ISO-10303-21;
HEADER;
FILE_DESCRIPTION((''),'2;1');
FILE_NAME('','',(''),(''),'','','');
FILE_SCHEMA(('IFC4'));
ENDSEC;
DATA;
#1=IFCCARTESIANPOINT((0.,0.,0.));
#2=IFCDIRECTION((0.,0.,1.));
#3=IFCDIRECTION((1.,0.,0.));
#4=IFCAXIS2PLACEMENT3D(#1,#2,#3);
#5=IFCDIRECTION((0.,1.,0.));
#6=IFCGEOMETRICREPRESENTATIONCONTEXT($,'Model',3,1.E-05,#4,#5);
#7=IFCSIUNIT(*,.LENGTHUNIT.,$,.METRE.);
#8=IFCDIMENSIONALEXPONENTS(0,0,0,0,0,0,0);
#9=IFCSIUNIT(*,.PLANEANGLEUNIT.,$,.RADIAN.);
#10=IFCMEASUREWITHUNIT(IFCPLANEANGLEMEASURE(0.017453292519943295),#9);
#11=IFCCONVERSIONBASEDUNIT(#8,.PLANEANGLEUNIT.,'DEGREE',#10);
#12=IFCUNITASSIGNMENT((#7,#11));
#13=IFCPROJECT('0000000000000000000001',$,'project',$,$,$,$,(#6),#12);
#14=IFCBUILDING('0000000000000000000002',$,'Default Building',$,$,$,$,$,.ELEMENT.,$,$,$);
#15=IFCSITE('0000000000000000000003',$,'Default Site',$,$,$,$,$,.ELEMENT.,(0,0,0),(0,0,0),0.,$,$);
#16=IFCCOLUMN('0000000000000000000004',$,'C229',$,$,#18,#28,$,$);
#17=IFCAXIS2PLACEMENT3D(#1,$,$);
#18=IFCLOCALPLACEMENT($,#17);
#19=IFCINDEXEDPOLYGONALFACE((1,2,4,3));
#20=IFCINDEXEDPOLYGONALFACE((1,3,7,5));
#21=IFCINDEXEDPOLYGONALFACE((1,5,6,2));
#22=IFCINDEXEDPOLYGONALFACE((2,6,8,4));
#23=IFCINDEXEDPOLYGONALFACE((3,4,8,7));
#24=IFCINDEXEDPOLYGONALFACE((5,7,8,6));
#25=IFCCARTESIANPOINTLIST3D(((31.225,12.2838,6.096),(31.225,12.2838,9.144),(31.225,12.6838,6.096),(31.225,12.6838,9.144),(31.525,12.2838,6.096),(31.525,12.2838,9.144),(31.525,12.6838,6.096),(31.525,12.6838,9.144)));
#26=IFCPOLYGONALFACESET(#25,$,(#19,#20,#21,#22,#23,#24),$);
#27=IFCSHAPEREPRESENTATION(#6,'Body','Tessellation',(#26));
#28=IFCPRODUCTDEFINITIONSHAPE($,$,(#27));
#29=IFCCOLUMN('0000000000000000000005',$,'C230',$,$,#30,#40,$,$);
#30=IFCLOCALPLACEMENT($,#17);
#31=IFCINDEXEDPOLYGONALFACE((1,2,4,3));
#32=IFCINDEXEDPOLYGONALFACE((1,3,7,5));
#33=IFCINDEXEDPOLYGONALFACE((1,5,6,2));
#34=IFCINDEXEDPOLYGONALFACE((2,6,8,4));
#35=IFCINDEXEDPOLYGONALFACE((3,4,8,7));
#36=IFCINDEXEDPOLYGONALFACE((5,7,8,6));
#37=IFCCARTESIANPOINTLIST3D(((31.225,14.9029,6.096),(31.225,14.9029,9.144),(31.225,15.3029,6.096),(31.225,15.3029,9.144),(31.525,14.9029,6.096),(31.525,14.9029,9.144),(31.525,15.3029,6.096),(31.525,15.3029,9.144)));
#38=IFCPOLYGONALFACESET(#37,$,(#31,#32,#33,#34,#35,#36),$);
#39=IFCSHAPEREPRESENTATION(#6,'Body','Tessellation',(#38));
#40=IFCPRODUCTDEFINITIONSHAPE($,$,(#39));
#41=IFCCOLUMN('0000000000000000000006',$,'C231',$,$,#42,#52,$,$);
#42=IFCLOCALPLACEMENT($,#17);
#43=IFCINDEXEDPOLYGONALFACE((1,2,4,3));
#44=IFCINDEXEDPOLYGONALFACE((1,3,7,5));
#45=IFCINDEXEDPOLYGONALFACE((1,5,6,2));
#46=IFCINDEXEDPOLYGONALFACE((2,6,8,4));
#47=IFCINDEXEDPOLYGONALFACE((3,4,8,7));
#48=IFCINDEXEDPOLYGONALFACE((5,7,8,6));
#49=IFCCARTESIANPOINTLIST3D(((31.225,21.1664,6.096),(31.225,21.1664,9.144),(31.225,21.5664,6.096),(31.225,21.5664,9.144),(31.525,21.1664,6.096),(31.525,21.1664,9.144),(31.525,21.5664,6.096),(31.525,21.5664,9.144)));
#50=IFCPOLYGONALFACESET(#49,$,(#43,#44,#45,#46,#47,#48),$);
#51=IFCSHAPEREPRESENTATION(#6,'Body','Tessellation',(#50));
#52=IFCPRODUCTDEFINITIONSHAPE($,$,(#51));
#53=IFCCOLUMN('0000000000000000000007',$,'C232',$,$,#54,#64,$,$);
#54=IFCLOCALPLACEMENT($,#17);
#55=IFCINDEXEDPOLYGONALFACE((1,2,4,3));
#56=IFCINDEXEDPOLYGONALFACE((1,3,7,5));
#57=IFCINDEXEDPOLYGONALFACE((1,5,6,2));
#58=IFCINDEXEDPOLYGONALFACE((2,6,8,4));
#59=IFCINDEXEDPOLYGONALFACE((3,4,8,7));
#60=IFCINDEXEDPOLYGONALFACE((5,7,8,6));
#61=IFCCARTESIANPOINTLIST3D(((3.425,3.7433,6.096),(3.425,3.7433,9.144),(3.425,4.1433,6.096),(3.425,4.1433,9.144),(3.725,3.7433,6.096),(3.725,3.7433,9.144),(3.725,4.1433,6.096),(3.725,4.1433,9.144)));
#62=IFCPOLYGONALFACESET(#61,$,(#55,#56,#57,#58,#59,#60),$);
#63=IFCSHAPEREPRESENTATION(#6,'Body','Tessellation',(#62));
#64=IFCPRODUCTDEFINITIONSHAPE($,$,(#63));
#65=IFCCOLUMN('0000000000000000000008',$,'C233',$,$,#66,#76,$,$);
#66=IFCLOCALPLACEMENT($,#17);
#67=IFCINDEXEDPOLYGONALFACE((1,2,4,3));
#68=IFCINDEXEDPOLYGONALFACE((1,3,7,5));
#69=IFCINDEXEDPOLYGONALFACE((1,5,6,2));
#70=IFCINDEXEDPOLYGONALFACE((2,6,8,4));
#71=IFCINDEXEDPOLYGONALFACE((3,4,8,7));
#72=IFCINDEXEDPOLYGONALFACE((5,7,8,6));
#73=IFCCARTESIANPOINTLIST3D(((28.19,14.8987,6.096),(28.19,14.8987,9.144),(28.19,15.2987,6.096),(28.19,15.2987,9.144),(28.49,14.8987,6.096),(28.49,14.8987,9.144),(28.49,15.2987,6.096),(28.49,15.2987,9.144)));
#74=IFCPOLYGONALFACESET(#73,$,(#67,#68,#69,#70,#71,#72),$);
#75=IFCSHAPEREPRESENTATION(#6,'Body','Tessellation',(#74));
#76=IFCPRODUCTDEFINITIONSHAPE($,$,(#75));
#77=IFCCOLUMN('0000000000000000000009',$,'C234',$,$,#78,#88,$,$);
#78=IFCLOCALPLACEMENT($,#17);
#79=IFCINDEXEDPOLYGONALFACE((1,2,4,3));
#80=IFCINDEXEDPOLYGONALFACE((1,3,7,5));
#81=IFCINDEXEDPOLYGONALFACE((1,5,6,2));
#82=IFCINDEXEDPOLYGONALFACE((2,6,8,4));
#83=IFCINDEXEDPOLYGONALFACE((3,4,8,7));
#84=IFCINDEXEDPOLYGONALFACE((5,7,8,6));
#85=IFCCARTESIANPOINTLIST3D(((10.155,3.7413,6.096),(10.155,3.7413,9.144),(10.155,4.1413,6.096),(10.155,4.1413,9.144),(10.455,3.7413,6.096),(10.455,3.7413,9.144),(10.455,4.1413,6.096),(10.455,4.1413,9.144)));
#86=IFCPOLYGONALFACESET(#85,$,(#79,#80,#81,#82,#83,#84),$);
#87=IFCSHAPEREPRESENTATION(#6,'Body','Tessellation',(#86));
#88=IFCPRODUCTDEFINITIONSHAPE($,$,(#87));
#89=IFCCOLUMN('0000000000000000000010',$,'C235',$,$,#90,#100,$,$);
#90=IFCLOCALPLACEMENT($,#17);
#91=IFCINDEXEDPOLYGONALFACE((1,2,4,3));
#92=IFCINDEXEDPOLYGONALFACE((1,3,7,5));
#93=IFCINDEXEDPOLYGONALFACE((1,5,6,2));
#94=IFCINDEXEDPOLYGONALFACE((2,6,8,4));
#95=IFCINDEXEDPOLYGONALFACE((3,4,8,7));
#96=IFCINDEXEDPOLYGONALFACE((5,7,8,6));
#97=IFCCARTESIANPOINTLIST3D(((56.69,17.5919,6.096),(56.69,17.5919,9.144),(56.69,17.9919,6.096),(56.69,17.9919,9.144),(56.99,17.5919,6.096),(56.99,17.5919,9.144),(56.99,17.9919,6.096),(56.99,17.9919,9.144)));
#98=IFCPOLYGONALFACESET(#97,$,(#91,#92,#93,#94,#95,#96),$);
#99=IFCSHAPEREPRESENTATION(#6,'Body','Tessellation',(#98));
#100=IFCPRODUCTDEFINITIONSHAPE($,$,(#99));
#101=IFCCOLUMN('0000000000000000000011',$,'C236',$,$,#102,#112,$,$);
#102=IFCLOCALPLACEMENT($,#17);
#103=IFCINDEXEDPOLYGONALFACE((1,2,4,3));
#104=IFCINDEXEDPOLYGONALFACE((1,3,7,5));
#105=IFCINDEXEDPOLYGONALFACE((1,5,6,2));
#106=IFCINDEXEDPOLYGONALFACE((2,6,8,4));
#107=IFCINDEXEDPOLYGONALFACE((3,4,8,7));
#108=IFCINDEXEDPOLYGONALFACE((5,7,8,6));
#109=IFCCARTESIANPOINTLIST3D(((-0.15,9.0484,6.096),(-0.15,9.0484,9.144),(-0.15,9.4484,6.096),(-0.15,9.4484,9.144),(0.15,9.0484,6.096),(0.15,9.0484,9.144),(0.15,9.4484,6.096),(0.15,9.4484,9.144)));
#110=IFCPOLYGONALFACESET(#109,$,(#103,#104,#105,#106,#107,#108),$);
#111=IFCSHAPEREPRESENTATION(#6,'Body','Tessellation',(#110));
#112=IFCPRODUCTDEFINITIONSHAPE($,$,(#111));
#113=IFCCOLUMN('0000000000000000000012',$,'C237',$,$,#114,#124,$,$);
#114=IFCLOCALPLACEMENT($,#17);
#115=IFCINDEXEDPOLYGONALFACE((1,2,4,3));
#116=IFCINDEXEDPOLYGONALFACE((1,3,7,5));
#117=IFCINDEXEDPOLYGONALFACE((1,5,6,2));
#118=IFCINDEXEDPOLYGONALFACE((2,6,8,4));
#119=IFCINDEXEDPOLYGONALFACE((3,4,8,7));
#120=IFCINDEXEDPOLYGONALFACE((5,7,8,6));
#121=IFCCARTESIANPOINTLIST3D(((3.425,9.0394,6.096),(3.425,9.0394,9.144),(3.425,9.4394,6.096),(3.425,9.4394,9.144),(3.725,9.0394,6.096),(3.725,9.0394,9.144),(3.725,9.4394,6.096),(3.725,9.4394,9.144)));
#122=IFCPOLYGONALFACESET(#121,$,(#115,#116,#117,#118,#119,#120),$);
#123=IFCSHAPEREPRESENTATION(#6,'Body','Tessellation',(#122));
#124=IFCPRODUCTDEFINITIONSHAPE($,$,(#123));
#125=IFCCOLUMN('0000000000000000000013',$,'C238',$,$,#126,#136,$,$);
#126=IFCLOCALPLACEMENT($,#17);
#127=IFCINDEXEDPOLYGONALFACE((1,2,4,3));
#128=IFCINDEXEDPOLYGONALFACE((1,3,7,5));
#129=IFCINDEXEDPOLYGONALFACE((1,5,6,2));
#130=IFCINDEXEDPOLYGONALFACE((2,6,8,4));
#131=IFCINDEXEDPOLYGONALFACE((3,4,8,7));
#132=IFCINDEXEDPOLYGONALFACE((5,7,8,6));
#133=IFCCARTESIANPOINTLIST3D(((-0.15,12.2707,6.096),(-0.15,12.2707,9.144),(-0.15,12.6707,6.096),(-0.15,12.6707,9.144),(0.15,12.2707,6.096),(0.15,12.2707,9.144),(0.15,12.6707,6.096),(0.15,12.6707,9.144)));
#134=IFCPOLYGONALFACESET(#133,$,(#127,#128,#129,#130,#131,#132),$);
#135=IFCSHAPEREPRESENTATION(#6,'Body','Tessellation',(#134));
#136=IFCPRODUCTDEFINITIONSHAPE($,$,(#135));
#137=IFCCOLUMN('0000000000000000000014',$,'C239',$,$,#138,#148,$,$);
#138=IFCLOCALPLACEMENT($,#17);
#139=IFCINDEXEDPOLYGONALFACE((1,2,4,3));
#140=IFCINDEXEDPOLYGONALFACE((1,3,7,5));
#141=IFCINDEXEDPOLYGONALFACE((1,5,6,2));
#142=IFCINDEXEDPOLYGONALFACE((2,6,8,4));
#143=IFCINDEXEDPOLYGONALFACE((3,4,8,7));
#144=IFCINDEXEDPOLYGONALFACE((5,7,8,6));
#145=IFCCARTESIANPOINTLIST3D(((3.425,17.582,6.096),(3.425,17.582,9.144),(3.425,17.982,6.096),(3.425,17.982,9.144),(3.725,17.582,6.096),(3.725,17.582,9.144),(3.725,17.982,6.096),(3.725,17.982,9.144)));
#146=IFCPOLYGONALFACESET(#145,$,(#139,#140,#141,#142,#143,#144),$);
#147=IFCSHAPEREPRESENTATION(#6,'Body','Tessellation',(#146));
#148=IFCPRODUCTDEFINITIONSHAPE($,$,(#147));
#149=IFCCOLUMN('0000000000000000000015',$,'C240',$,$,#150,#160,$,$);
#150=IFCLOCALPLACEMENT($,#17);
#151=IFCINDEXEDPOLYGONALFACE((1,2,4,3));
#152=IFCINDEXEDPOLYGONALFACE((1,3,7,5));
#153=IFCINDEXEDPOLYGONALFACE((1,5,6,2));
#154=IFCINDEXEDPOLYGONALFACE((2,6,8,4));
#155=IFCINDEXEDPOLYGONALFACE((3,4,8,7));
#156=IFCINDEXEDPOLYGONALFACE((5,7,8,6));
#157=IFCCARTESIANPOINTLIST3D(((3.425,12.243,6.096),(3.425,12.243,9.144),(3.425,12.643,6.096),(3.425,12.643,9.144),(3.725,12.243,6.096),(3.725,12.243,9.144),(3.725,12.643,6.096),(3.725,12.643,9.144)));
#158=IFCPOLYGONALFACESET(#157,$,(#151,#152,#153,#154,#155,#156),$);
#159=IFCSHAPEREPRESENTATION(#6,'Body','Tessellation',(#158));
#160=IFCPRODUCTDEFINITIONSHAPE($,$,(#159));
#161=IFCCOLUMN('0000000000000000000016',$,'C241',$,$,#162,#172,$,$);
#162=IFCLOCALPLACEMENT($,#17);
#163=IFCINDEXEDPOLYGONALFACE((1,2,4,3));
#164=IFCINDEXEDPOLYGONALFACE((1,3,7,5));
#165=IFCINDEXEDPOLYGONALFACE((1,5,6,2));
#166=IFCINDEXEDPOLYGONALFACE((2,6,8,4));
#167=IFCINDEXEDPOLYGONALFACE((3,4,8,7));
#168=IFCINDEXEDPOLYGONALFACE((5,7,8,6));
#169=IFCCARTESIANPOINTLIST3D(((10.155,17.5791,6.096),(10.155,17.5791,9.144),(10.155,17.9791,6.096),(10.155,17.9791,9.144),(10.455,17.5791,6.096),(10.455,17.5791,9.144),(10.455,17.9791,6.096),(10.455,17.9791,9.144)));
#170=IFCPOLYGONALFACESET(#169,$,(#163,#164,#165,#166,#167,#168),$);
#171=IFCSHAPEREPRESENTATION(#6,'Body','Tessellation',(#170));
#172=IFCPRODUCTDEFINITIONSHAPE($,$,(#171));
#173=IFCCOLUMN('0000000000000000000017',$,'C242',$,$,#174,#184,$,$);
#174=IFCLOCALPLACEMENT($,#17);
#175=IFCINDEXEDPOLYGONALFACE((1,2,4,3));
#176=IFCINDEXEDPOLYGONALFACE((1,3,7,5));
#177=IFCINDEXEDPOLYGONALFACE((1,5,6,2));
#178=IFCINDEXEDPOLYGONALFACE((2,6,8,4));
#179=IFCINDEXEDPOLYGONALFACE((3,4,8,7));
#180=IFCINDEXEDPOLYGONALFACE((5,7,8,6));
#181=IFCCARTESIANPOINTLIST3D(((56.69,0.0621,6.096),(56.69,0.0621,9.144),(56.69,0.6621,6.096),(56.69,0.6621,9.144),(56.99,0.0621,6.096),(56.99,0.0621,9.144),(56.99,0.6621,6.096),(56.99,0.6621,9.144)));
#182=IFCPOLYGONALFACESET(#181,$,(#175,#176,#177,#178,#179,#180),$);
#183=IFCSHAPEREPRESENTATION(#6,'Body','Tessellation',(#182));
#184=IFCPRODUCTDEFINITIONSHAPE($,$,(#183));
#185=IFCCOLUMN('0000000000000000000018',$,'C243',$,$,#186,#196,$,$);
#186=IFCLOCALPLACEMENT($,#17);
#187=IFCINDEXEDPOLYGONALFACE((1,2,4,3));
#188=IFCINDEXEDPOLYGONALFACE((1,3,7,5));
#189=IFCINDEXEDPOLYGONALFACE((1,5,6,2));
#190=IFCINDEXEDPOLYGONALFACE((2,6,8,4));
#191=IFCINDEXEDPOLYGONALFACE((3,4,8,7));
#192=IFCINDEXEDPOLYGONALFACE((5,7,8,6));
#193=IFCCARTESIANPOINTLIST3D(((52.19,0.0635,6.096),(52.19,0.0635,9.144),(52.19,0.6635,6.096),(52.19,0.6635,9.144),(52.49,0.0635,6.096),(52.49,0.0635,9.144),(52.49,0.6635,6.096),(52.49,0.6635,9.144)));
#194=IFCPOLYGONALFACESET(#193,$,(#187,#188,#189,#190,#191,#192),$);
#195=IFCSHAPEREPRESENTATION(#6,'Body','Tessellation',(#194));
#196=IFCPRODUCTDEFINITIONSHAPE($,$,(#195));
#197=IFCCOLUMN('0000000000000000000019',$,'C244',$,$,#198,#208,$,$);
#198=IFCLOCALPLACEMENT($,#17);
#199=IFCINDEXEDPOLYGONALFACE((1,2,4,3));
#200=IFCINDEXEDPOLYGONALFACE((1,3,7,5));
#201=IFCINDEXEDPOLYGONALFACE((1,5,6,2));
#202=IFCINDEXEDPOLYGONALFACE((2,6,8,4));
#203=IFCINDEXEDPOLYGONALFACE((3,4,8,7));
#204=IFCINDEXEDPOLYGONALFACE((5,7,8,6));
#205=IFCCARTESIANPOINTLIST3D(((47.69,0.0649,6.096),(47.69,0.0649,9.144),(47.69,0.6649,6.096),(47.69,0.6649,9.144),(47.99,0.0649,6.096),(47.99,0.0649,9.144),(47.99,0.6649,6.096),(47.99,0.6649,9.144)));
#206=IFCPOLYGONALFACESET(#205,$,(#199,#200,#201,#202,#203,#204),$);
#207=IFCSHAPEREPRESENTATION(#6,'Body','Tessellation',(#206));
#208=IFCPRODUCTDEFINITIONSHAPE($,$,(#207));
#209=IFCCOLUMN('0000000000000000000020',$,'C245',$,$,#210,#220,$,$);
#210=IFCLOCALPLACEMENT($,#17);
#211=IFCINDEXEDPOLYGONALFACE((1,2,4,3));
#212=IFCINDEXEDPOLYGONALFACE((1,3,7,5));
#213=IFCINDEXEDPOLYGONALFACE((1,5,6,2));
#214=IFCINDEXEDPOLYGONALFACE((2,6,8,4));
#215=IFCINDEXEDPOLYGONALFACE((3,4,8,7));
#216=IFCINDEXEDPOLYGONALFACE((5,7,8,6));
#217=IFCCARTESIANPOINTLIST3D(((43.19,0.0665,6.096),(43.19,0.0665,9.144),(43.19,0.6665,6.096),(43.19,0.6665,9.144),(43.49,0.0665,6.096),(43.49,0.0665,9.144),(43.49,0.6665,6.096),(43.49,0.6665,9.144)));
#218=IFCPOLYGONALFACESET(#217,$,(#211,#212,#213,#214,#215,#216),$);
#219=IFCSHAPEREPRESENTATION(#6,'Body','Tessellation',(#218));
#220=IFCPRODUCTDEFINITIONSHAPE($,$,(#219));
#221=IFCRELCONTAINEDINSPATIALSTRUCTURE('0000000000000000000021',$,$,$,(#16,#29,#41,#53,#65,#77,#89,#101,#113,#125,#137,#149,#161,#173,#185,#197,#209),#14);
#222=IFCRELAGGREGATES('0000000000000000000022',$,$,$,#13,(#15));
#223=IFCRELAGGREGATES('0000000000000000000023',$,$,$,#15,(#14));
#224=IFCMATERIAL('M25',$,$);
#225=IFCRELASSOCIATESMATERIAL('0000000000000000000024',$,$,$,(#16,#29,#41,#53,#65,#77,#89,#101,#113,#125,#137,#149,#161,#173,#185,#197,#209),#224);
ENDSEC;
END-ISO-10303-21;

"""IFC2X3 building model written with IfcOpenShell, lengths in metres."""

from ifc_helpers import new_model, entity, si_unit, converted_unit, direction, frame, frame_2d, origin_with_axes, place, context, project, spatial, rectangle, extrude, material, element, save


model = new_model("IFC2X3")

# Units and contexts
model_context = context("Model", 3, precision=1e-05, world=origin_with_axes(), true_north=direction((0.0, 1.0, 0.0)))
ifc_project = project(units=[si_unit("LENGTHUNIT", "METRE"), converted_unit("PLANEANGLEUNIT", "DEGREE", entity("IfcPlaneAngleMeasure", 0.017453292519943295), si_unit("PLANEANGLEUNIT", "RADIAN"), dimensions=[0, 0, 0, 0, 0, 0, 0])], contexts=[model_context])

# Site, building
site = spatial("IfcSite", under=ifc_project, Name="Default Site", CompositionType="ELEMENT", RefLatitude=(0, 0, 0), RefLongitude=(0, 0, 0), RefElevation=0.0)
building = spatial("IfcBuilding", under=site, Name="Default Building", CompositionType="ELEMENT")

# Columns
ifc_material = material(Name="M25")
placement = place(None, origin_with_axes())
element("IfcColumn", 1, at=placement, inside=building, material=ifc_material, Name="C229", context=model_context, shape_type="SweptSolid", body=[
    extrude(rectangle(XDim=0.3, YDim=0.4, at=frame_2d((0.0, 0.0), x_axis=(1.0, 0.0, 0.0))), frame((31.375, 12.4838, 6.096), z_axis=(0.0, 0.0, 1.0), x_axis=(1.0, 0.0, 0.0)), (0.0, 0.0, 1.0), 3.048),
])
element("IfcColumn", 2, at=placement, inside=building, material=ifc_material, Name="C230", context=model_context, shape_type="SweptSolid", body=[
    extrude(rectangle(XDim=0.3, YDim=0.4, at=frame_2d((0.0, 0.0), x_axis=(1.0, 0.0, 0.0))), frame((31.375, 15.1029, 6.096), z_axis=(0.0, 0.0, 1.0), x_axis=(1.0, 0.0, 0.0)), (0.0, 0.0, 1.0), 3.048),
])
element("IfcColumn", 3, at=placement, inside=building, material=ifc_material, Name="C231", context=model_context, shape_type="SweptSolid", body=[
    extrude(rectangle(XDim=0.3, YDim=0.4, at=frame_2d((0.0, 0.0), x_axis=(1.0, 0.0, 0.0))), frame((31.375, 21.3664, 6.096), z_axis=(0.0, 0.0, 1.0), x_axis=(1.0, 0.0, 0.0)), (0.0, 0.0, 1.0), 3.048),
])
element("IfcColumn", 4, at=placement, inside=building, material=ifc_material, Name="C232", context=model_context, shape_type="SweptSolid", body=[
    extrude(rectangle(XDim=0.3, YDim=0.4, at=frame_2d((0.0, 0.0), x_axis=(1.0, 0.0, 0.0))), frame((3.575, 3.9433, 6.096), z_axis=(0.0, 0.0, 1.0), x_axis=(1.0, 0.0, 0.0)), (0.0, 0.0, 1.0), 3.048),
])
element("IfcColumn", 5, at=placement, inside=building, material=ifc_material, Name="C233", context=model_context, shape_type="SweptSolid", body=[
    extrude(rectangle(XDim=0.3, YDim=0.4, at=frame_2d((0.0, 0.0), x_axis=(1.0, 0.0, 0.0))), frame((28.34, 15.0987, 6.096), z_axis=(0.0, 0.0, 1.0), x_axis=(1.0, 0.0, 0.0)), (0.0, 0.0, 1.0), 3.048),
])
element("IfcColumn", 6, at=placement, inside=building, material=ifc_material, Name="C234", context=model_context, shape_type="SweptSolid", body=[
    extrude(rectangle(XDim=0.3, YDim=0.4, at=frame_2d((0.0, 0.0), x_axis=(1.0, 0.0, 0.0))), frame((10.305, 3.9413, 6.096), z_axis=(0.0, 0.0, 1.0), x_axis=(1.0, 0.0, 0.0)), (0.0, 0.0, 1.0), 3.048),
])
element("IfcColumn", 7, at=placement, inside=building, material=ifc_material, Name="C235", context=model_context, shape_type="SweptSolid", body=[
    extrude(rectangle(XDim=0.3, YDim=0.4, at=frame_2d((0.0, 0.0), x_axis=(1.0, 0.0, 0.0))), frame((56.84, 17.7919, 6.096), z_axis=(0.0, 0.0, 1.0), x_axis=(1.0, 0.0, 0.0)), (0.0, 0.0, 1.0), 3.048),
])
element("IfcColumn", 8, at=placement, inside=building, material=ifc_material, Name="C236", context=model_context, shape_type="SweptSolid", body=[
    extrude(rectangle(XDim=0.3, YDim=0.4, at=frame_2d((0.0, 0.0), x_axis=(1.0, 0.0, 0.0))), frame((0.0, 9.2484, 6.096), z_axis=(0.0, 0.0, 1.0), x_axis=(1.0, 0.0, 0.0)), (0.0, 0.0, 1.0), 3.048),
])
element("IfcColumn", 9, at=placement, inside=building, material=ifc_material, Name="C237", context=model_context, shape_type="SweptSolid", body=[
    extrude(rectangle(XDim=0.3, YDim=0.4, at=frame_2d((0.0, 0.0), x_axis=(1.0, 0.0, 0.0))), frame((3.575, 9.2394, 6.096), z_axis=(0.0, 0.0, 1.0), x_axis=(1.0, 0.0, 0.0)), (0.0, 0.0, 1.0), 3.048),
])
element("IfcColumn", 10, at=placement, inside=building, material=ifc_material, Name="C238", context=model_context, shape_type="SweptSolid", body=[
    extrude(rectangle(XDim=0.3, YDim=0.4, at=frame_2d((0.0, 0.0), x_axis=(1.0, 0.0, 0.0))), frame((0.0, 12.4707, 6.096), z_axis=(0.0, 0.0, 1.0), x_axis=(1.0, 0.0, 0.0)), (0.0, 0.0, 1.0), 3.048),
])
element("IfcColumn", 11, at=placement, inside=building, material=ifc_material, Name="C239", context=model_context, shape_type="SweptSolid", body=[
    extrude(rectangle(XDim=0.3, YDim=0.4, at=frame_2d((0.0, 0.0), x_axis=(1.0, 0.0, 0.0))), frame((3.575, 17.782, 6.096), z_axis=(0.0, 0.0, 1.0), x_axis=(1.0, 0.0, 0.0)), (0.0, 0.0, 1.0), 3.048),
])
element("IfcColumn", 12, at=placement, inside=building, material=ifc_material, Name="C240", context=model_context, shape_type="SweptSolid", body=[
    extrude(rectangle(XDim=0.3, YDim=0.4, at=frame_2d((0.0, 0.0), x_axis=(1.0, 0.0, 0.0))), frame((3.575, 12.443, 6.096), z_axis=(0.0, 0.0, 1.0), x_axis=(1.0, 0.0, 0.0)), (0.0, 0.0, 1.0), 3.048),
])
element("IfcColumn", 13, at=placement, inside=building, material=ifc_material, Name="C241", context=model_context, shape_type="SweptSolid", body=[
    extrude(rectangle(XDim=0.3, YDim=0.4, at=frame_2d((0.0, 0.0), x_axis=(1.0, 0.0, 0.0))), frame((10.305, 17.7791, 6.096), z_axis=(0.0, 0.0, 1.0), x_axis=(1.0, 0.0, 0.0)), (0.0, 0.0, 1.0), 3.048),
])
element("IfcColumn", 14, at=placement, inside=building, material=ifc_material, Name="C242", context=model_context, shape_type="SweptSolid", body=[
    extrude(rectangle(XDim=0.3, YDim=0.6, at=frame_2d((0.0, 0.0), x_axis=(1.0, 0.0, 0.0))), frame((56.84, 0.3621, 6.096), z_axis=(0.0, 0.0, 1.0), x_axis=(1.0, 0.0, 0.0)), (0.0, 0.0, 1.0), 3.048),
])
element("IfcColumn", 15, at=placement, inside=building, material=ifc_material, Name="C243", context=model_context, shape_type="SweptSolid", body=[
    extrude(rectangle(XDim=0.3, YDim=0.6, at=frame_2d((0.0, 0.0), x_axis=(1.0, 0.0, 0.0))), frame((52.34, 0.3635, 6.096), z_axis=(0.0, 0.0, 1.0), x_axis=(1.0, 0.0, 0.0)), (0.0, 0.0, 1.0), 3.048),
])
element("IfcColumn", 16, at=placement, inside=building, material=ifc_material, Name="C244", context=model_context, shape_type="SweptSolid", body=[
    extrude(rectangle(XDim=0.3, YDim=0.6, at=frame_2d((0.0, 0.0), x_axis=(1.0, 0.0, 0.0))), frame((47.84, 0.3649, 6.096), z_axis=(0.0, 0.0, 1.0), x_axis=(1.0, 0.0, 0.0)), (0.0, 0.0, 1.0), 3.048),
])
element("IfcColumn", 17, at=placement, inside=building, material=ifc_material, Name="C245", context=model_context, shape_type="SweptSolid", body=[
    extrude(rectangle(XDim=0.3, YDim=0.6, at=frame_2d((0.0, 0.0), x_axis=(1.0, 0.0, 0.0))), frame((43.34, 0.3665, 6.096), z_axis=(0.0, 0.0, 1.0), x_axis=(1.0, 0.0, 0.0)), (0.0, 0.0, 1.0), 3.048),
])

save(model, "model.ifc")
